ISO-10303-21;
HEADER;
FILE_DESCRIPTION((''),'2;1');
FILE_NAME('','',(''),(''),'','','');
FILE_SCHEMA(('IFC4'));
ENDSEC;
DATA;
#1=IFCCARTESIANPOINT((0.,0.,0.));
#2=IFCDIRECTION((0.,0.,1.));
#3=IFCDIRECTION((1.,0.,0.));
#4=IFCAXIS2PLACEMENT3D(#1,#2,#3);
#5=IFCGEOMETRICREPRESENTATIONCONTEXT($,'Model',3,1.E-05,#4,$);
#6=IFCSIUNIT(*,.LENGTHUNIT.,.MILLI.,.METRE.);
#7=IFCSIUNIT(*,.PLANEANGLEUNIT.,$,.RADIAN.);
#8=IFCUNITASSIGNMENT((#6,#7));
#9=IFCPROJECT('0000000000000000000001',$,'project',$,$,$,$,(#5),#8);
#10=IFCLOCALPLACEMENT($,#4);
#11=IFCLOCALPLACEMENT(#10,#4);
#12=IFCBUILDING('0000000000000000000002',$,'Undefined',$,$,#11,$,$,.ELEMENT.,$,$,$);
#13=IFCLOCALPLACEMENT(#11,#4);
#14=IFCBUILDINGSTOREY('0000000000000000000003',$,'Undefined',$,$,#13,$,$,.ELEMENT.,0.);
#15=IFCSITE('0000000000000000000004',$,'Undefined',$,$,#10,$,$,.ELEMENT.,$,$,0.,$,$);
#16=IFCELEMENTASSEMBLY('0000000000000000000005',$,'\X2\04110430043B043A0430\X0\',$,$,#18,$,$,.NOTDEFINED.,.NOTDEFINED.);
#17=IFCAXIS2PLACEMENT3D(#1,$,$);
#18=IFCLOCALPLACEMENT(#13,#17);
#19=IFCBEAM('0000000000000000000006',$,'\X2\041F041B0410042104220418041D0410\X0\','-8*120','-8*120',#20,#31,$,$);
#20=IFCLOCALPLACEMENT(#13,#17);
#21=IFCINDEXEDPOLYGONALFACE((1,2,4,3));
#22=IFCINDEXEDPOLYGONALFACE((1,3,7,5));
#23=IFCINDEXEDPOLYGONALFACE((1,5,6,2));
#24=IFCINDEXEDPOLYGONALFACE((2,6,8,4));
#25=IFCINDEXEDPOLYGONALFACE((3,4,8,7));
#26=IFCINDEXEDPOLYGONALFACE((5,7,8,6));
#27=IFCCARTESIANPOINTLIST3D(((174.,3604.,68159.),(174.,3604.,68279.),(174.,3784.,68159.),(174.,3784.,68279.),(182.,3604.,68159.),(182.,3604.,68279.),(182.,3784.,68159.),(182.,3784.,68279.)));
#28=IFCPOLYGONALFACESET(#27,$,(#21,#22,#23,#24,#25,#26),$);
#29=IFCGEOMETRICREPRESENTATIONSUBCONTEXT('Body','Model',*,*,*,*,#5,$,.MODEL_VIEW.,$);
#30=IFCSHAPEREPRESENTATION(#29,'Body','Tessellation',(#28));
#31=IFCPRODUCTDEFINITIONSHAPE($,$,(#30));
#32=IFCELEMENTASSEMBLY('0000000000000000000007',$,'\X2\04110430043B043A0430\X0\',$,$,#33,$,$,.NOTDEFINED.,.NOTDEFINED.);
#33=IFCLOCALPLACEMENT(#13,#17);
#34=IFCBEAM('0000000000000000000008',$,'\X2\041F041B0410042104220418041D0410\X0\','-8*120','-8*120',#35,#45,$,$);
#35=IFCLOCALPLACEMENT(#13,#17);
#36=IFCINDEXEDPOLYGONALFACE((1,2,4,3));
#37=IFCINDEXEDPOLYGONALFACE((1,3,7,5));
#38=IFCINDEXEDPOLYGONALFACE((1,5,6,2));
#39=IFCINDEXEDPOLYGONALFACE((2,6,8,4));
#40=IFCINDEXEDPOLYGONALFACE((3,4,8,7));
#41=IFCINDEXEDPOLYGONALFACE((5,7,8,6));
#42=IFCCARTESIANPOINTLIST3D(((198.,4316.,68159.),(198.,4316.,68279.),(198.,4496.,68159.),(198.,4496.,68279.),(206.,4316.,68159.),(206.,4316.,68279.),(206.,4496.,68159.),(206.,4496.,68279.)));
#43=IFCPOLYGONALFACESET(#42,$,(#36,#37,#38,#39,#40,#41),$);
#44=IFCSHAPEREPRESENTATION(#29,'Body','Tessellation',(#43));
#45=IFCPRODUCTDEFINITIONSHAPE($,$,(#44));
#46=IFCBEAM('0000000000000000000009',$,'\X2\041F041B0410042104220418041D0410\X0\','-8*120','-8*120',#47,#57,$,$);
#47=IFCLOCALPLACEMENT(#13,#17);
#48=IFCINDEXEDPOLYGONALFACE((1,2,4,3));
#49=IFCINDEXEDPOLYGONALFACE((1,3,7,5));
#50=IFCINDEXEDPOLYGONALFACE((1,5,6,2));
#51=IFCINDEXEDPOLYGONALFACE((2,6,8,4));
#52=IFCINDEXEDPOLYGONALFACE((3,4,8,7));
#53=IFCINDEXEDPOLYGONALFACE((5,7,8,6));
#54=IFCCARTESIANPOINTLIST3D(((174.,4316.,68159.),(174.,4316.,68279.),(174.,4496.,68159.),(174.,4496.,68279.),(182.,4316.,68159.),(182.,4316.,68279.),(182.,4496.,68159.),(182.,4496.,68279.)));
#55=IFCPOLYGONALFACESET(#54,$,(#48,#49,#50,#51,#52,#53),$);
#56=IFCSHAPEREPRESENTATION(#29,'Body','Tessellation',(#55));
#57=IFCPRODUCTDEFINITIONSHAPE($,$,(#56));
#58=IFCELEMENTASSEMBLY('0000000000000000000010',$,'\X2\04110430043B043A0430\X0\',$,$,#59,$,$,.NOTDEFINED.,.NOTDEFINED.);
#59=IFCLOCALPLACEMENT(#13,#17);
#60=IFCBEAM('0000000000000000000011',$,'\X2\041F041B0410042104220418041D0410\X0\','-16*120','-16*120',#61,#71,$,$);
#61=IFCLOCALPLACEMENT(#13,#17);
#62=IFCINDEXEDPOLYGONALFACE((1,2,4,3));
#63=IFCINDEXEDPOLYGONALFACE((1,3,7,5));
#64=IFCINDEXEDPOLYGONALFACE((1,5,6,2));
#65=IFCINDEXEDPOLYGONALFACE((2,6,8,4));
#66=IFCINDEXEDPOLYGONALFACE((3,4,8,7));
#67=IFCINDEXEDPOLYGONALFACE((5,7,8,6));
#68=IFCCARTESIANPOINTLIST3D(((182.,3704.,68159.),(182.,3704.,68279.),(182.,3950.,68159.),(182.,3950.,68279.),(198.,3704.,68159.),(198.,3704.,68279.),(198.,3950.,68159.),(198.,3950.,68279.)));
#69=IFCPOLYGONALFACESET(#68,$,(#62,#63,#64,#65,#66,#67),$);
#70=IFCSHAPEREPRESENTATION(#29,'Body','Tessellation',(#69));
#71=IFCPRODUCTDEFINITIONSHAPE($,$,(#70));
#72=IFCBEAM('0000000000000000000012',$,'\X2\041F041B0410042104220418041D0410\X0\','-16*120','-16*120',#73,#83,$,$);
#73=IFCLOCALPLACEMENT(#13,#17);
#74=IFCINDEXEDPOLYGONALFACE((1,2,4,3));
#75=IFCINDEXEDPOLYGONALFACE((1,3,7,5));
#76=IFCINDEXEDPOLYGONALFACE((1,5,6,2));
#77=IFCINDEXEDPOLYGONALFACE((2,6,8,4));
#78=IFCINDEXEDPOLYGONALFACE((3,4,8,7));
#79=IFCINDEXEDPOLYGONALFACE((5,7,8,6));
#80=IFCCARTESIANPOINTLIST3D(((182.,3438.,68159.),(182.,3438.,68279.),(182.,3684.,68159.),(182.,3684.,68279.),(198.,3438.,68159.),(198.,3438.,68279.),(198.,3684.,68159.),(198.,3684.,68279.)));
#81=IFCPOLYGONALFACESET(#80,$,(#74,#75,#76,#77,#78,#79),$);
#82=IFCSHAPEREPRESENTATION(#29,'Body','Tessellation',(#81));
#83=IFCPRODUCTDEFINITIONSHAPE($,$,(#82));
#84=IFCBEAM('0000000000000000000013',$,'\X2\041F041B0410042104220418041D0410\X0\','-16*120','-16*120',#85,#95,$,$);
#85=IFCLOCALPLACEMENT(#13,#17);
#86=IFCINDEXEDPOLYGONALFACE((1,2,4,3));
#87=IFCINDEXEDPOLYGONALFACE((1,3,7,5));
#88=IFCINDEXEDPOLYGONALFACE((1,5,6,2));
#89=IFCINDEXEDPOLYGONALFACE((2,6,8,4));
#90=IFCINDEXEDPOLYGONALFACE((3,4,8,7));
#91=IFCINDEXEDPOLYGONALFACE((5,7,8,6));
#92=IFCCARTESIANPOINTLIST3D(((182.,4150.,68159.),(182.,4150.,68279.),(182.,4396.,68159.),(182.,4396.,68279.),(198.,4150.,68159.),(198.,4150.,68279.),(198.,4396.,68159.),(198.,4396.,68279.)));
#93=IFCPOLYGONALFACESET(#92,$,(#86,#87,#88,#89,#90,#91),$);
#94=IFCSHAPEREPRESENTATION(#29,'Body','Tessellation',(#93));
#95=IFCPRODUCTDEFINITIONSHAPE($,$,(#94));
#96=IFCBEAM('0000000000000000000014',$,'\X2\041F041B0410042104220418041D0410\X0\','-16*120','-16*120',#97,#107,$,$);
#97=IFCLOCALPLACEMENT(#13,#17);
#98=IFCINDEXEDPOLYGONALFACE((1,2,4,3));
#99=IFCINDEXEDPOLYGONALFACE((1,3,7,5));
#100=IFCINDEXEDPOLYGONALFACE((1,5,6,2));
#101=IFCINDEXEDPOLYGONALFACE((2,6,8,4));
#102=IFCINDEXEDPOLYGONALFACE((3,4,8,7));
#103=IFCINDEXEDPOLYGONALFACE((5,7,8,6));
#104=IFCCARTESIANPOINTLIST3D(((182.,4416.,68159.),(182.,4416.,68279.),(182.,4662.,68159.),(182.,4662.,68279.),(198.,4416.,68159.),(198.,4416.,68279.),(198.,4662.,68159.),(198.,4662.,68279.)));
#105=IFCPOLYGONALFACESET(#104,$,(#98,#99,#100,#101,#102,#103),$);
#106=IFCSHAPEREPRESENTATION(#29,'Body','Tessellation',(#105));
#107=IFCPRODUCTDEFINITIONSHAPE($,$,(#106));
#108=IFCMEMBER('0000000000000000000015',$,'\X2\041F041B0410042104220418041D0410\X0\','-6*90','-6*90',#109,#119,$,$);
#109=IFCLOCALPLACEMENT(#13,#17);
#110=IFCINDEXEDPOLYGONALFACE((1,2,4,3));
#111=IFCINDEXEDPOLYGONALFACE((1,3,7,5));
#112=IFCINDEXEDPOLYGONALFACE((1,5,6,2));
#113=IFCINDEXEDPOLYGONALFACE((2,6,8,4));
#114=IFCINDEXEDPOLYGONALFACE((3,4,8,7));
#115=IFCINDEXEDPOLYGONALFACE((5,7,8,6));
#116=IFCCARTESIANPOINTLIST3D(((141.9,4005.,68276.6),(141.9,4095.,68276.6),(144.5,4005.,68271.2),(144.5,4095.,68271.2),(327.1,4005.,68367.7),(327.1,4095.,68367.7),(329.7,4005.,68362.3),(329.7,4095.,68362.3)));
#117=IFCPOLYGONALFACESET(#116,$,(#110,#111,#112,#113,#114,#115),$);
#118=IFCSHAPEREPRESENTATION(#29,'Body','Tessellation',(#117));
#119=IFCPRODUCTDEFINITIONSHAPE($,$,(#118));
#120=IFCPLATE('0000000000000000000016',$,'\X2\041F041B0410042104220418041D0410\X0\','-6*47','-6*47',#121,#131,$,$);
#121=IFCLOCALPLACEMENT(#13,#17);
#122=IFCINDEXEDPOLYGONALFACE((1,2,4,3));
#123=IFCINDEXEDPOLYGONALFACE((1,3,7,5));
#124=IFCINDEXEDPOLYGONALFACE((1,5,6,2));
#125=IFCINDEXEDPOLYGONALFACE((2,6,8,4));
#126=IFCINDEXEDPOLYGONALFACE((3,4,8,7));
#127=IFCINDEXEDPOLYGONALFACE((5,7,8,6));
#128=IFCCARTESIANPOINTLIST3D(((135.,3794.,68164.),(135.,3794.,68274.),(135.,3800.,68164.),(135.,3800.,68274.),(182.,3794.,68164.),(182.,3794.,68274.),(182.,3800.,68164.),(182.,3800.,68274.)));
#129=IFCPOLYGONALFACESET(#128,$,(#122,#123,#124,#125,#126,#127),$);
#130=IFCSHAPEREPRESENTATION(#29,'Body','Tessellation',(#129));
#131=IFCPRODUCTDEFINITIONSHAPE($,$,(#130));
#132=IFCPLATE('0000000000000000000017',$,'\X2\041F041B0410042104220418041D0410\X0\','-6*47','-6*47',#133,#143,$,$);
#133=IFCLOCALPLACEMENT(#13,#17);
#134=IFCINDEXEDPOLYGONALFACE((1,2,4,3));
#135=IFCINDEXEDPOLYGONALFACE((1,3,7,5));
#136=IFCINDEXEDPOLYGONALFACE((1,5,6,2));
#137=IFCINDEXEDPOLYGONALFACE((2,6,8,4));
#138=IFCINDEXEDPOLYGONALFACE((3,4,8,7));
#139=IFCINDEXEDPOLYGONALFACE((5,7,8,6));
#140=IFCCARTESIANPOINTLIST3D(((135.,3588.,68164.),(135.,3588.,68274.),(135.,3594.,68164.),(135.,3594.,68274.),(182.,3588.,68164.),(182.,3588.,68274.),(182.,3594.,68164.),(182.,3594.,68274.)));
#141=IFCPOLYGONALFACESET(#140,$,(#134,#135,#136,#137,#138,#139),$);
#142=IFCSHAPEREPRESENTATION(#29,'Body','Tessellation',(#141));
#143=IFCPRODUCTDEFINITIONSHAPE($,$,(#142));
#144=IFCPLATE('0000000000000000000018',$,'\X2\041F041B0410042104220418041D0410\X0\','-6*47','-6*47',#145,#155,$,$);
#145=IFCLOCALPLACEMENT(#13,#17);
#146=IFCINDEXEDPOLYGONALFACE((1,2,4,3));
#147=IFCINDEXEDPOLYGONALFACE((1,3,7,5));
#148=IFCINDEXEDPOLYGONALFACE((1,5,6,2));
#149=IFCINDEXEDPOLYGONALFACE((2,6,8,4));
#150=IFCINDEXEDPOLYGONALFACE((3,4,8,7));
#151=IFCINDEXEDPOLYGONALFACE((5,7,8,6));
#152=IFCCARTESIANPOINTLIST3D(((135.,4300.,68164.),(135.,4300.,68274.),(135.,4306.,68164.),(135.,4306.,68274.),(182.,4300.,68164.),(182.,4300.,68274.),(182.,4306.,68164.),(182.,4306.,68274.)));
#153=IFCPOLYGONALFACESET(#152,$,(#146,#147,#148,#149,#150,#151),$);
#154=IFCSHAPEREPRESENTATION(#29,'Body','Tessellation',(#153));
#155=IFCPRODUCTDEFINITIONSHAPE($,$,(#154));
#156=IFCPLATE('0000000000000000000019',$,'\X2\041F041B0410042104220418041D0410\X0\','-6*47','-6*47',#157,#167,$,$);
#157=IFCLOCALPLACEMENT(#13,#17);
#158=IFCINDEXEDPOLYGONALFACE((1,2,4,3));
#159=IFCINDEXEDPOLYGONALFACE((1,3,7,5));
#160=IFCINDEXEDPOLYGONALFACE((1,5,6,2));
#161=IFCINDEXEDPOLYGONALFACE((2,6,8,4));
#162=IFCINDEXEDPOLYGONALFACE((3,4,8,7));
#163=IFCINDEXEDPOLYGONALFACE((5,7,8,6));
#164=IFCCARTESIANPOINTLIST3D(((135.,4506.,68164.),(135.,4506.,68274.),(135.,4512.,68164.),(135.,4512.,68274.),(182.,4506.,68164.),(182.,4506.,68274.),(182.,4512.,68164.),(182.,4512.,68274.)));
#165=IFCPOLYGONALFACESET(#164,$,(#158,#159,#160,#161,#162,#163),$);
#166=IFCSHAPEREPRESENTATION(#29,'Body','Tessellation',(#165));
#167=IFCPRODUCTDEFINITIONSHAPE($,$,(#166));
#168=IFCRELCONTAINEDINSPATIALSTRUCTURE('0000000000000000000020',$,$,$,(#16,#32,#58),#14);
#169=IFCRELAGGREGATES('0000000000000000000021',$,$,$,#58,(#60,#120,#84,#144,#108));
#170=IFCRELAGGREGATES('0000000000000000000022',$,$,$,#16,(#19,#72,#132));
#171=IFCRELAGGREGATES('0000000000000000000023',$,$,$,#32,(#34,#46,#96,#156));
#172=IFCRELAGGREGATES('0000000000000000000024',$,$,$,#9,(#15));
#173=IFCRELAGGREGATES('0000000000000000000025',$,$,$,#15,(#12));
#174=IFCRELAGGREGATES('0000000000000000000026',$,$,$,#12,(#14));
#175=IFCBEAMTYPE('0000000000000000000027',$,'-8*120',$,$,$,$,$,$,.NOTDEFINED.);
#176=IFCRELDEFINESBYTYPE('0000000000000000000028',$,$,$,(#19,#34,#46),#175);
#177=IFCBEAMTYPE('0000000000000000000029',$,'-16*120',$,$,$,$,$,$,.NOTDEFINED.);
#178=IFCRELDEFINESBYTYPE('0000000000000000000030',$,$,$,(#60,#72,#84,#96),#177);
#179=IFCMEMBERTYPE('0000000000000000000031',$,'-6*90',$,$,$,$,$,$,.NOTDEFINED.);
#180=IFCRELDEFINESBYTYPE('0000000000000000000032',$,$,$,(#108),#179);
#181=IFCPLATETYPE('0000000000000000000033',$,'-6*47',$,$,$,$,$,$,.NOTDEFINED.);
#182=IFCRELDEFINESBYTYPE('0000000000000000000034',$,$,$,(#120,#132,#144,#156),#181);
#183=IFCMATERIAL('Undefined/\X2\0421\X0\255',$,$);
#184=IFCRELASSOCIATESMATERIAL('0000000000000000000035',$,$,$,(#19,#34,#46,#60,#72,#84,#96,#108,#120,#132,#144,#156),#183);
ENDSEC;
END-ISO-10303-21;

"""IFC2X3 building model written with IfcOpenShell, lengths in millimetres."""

from ifc_helpers import new_model, si_unit, frame, origin_with_axes, origin_2d_with_axis, place, context, subcontext, project, spatial, polyline, rectangle, outline, extrude, boolean, material, type_object, element, aggregate, save


model = new_model("IFC2X3")

# Units and contexts
model_context = context("Model", 3, precision=1e-05, world=origin_with_axes())
body_context = subcontext(model_context, "Body", "Model", "MODEL_VIEW")
ifc_project = project(units=[si_unit("LENGTHUNIT", "METRE", prefix="MILLI"), si_unit("PLANEANGLEUNIT", "RADIAN")], contexts=[model_context])

# Site, building, storey
site_placement = place(None, origin_with_axes())
site = spatial("IfcSite", under=ifc_project, at=site_placement, Name="Undefined", CompositionType="ELEMENT", RefElevation=0.0)
building_placement = place(site_placement, origin_with_axes())
building = spatial("IfcBuilding", under=site, at=building_placement, Name="Undefined", CompositionType="ELEMENT")
storey_placement = place(building_placement, origin_with_axes())
storey = spatial("IfcBuildingStorey", under=building, at=storey_placement, Name="Undefined", CompositionType="ELEMENT", Elevation=0.0)

# Element assembly, beam
assembly_1_placement = place(storey_placement, origin_with_axes())
assembly_1 = element("IfcElementAssembly", 1, at=assembly_1_placement, inside=storey, Name="Балка", AssemblyPlace="NOTDEFINED", PredefinedType="NOTDEFINED")
ifc_material_1 = material(Name="Undefined/С255")
beam_type_1 = type_object("IfcBeamType", Name="-8*120", PredefinedType="NOTDEFINED")
beam_1_placement = place(assembly_1_placement, frame((178.0, 3604.0, 68219.0), z_axis=(0.0, 0.0, 1.0), x_axis=(0.0, 1.0, 0.0)))
beam_1 = element("IfcBeam", 2, at=beam_1_placement, type_object=beam_type_1, material=ifc_material_1, Name="ПЛАСТИНА", Description="-8*120", ObjectType="-8*120", context=body_context, shape_type="SweptSolid", body=[
    extrude(rectangle(XDim=8.0, YDim=120.0, at=origin_2d_with_axis()), frame((180.0, 0.0, 0.0), z_axis=(-1.0, 0.0, 0.0), x_axis=(0.0, -1.0, 0.0)), (0.0, 0.0, 1.0), 180.0),
])

# Element assembly, beams
assembly_2_placement = place(storey_placement, origin_with_axes())
assembly_2 = element("IfcElementAssembly", 3, at=assembly_2_placement, inside=storey, Name="Балка", AssemblyPlace="NOTDEFINED", PredefinedType="NOTDEFINED")
beam_2_placement = place(assembly_2_placement, frame((202.0, 4496.0, 68219.0), z_axis=(0.0, 0.0, -1.0), x_axis=(0.0, -1.0, 0.0)))
beam_2 = element("IfcBeam", 4, at=beam_2_placement, type_object=beam_type_1, material=ifc_material_1, Name="ПЛАСТИНА", Description="-8*120", ObjectType="-8*120", context=body_context, shape_type="SweptSolid", body=[
    extrude(rectangle(XDim=8.0, YDim=120.0, at=origin_2d_with_axis()), frame((180.0, 0.0, 0.0), z_axis=(-1.0, 0.0, 0.0), x_axis=(0.0, -1.0, 0.0)), (0.0, 0.0, 1.0), 180.0),
])
beam_3_placement = place(assembly_2_placement, frame((178.0, 4496.0, 68219.0), z_axis=(0.0, 0.0, -1.0), x_axis=(0.0, -1.0, 0.0)))
beam_3 = element("IfcBeam", 5, at=beam_3_placement, type_object=beam_type_1, material=ifc_material_1, Name="ПЛАСТИНА", Description="-8*120", ObjectType="-8*120", context=body_context, shape_type="SweptSolid", body=[
    extrude(rectangle(XDim=8.0, YDim=120.0, at=origin_2d_with_axis()), frame((180.0, 0.0, 0.0), z_axis=(-1.0, 0.0, 0.0), x_axis=(0.0, -1.0, 0.0)), (0.0, 0.0, 1.0), 180.0),
])

# Element assembly, beam
assembly_3_placement = place(storey_placement, origin_with_axes())
assembly_3 = element("IfcElementAssembly", 6, at=assembly_3_placement, inside=storey, Name="Балка", AssemblyPlace="NOTDEFINED", PredefinedType="NOTDEFINED")
beam_type_2 = type_object("IfcBeamType", Name="-16*120", PredefinedType="NOTDEFINED")
beam_4_placement = place(assembly_3_placement, frame((190.0, 3704.0, 68219.0), z_axis=(0.0, 0.0, 1.0), x_axis=(0.0, 1.0, 0.0)))
beam_4 = element("IfcBeam", 7, at=beam_4_placement, type_object=beam_type_2, material=ifc_material_1, Name="ПЛАСТИНА", Description="-16*120", ObjectType="-16*120", context=body_context, shape_type="SweptSolid", body=[
    extrude(rectangle(XDim=16.0, YDim=120.0, at=origin_2d_with_axis()), frame((246.0, 0.0, 0.0), z_axis=(-1.0, 0.0, 0.0), x_axis=(0.0, -1.0, 0.0)), (0.0, 0.0, 1.0), 246.0),
])

# Beams
beam_5_placement = place(assembly_1_placement, frame((190.0, 3438.0, 68219.0), z_axis=(0.0, 0.0, 1.0), x_axis=(0.0, 1.0, 0.0)))
beam_5 = element("IfcBeam", 8, at=beam_5_placement, type_object=beam_type_2, material=ifc_material_1, Name="ПЛАСТИНА", Description="-16*120", ObjectType="-16*120", context=body_context, shape_type="SweptSolid", body=[
    extrude(rectangle(XDim=16.0, YDim=120.0, at=origin_2d_with_axis()), frame((246.0, 0.0, 0.0), z_axis=(-1.0, 0.0, 0.0), x_axis=(0.0, -1.0, 0.0)), (0.0, 0.0, 1.0), 246.0),
])
beam_6_placement = place(assembly_3_placement, frame((190.0, 4396.0, 68219.0), z_axis=(0.0, 0.0, -1.0), x_axis=(0.0, -1.0, 0.0)))
beam_6 = element("IfcBeam", 9, at=beam_6_placement, type_object=beam_type_2, material=ifc_material_1, Name="ПЛАСТИНА", Description="-16*120", ObjectType="-16*120", context=body_context, shape_type="SweptSolid", body=[
    extrude(rectangle(XDim=16.0, YDim=120.0, at=origin_2d_with_axis()), frame((246.0, 0.0, 0.0), z_axis=(-1.0, 0.0, 0.0), x_axis=(0.0, -1.0, 0.0)), (0.0, 0.0, 1.0), 246.0),
])
beam_7_placement = place(assembly_2_placement, frame((190.0, 4662.0, 68219.0), z_axis=(0.0, 0.0, -1.0), x_axis=(0.0, -1.0, 0.0)))
beam_7 = element("IfcBeam", 10, at=beam_7_placement, type_object=beam_type_2, material=ifc_material_1, Name="ПЛАСТИНА", Description="-16*120", ObjectType="-16*120", context=body_context, shape_type="SweptSolid", body=[
    extrude(rectangle(XDim=16.0, YDim=120.0, at=origin_2d_with_axis()), frame((246.0, 0.0, 0.0), z_axis=(-1.0, 0.0, 0.0), x_axis=(0.0, -1.0, 0.0)), (0.0, 0.0, 1.0), 246.0),
])

# Member
member_type = type_object("IfcMemberType", Name="-6*90", PredefinedType="NOTDEFINED")
member_placement = place(assembly_3_placement, frame((143.2, 4050.0, 68273.9), z_axis=(0.0, -1.0, 0.0), x_axis=(0.897399, 0.0, 0.441221)))
member = element("IfcMember", 11, at=member_placement, type_object=member_type, material=ifc_material_1, Name="ПЛАСТИНА", Description="-6*90", ObjectType="-6*90", context=body_context, shape_type="SweptSolid", body=[
    extrude(rectangle(XDim=6.0, YDim=90.0, at=origin_2d_with_axis()), frame((206.4, 0.0, 0.0), z_axis=(-1.0, 0.0, 0.0), x_axis=(0.0, -1.0, 0.0)), (0.0, 0.0, 1.0), 206.4),
])

# Plates
plate_type = type_object("IfcPlateType", Name="-6*47", PredefinedType="NOTDEFINED")
plate_1_placement = place(assembly_3_placement, frame((135.0, 3797.0, 68274.0), z_axis=(0.0, -1.0, 0.0), x_axis=(0.0, 0.0, -1.0)))
plate_1 = element("IfcPlate", 12, at=plate_1_placement, type_object=plate_type, material=ifc_material_1, Name="ПЛАСТИНА", Description="-6*47", ObjectType="-6*47", context=body_context, shape_type="CSG", body=[
    boolean("DIFFERENCE", extrude(outline(polyline([(0.0, 0.0), (110.0, 0.0), (110.0, 110.0), (0.0, 110.0), (0.0, 0.0)])), frame((0.0, 0.0, -3.0), z_axis=(0.0, 0.0, 1.0), x_axis=(1.0, 0.0, 0.0)), (0.0, 0.0, 1.0), 6.0), extrude(rectangle(XDim=26.0, YDim=130.0, at=origin_2d_with_axis()), frame((55.0, 47.0, 0.0), z_axis=(0.0, 1.0, 0.0), x_axis=(0.0, 0.0, -1.0)), (0.0, 0.0, 1.0), 66.0)),
])
plate_2_placement = place(assembly_1_placement, frame((135.0, 3591.0, 68164.0), z_axis=(0.0, 1.0, 0.0), x_axis=(0.0, 0.0, 1.0)))
plate_2 = element("IfcPlate", 13, at=plate_2_placement, type_object=plate_type, material=ifc_material_1, Name="ПЛАСТИНА", Description="-6*47", ObjectType="-6*47", context=body_context, shape_type="CSG", body=[
    boolean("DIFFERENCE", extrude(outline(polyline([(0.0, 0.0), (110.0, 0.0), (110.0, 110.0), (0.0, 110.0), (0.0, 0.0)])), frame((0.0, 0.0, -3.0), z_axis=(0.0, 0.0, 1.0), x_axis=(1.0, 0.0, 0.0)), (0.0, 0.0, 1.0), 6.0), extrude(rectangle(XDim=26.0, YDim=130.0, at=origin_2d_with_axis()), frame((55.0, 47.0, 0.0), z_axis=(0.0, 1.0, 0.0), x_axis=(0.0, 0.0, -1.0)), (0.0, 0.0, 1.0), 66.0)),
])
plate_3_placement = place(assembly_3_placement, frame((135.0, 4303.0, 68164.0), z_axis=(0.0, 1.0, 0.0), x_axis=(0.0, 0.0, 1.0)))
plate_3 = element("IfcPlate", 14, at=plate_3_placement, type_object=plate_type, material=ifc_material_1, Name="ПЛАСТИНА", Description="-6*47", ObjectType="-6*47", context=body_context, shape_type="CSG", body=[
    boolean("DIFFERENCE", extrude(outline(polyline([(0.0, 0.0), (110.0, 0.0), (110.0, 110.0), (0.0, 110.0), (0.0, 0.0)])), frame((0.0, 0.0, -3.0), z_axis=(0.0, 0.0, 1.0), x_axis=(1.0, 0.0, 0.0)), (0.0, 0.0, 1.0), 6.0), extrude(rectangle(XDim=26.0, YDim=130.0, at=origin_2d_with_axis()), frame((55.0, 47.0, 0.0), z_axis=(0.0, 1.0, 0.0), x_axis=(0.0, 0.0, -1.0)), (0.0, 0.0, 1.0), 66.0)),
])
aggregate(assembly_3, [beam_4, plate_1, beam_6, plate_3, member])
plate_4_placement = place(assembly_2_placement, frame((135.0, 4509.0, 68274.0), z_axis=(0.0, -1.0, 0.0), x_axis=(0.0, 0.0, -1.0)))
plate_4 = element("IfcPlate", 15, at=plate_4_placement, type_object=plate_type, material=ifc_material_1, Name="ПЛАСТИНА", Description="-6*47", ObjectType="-6*47", context=body_context, shape_type="CSG", body=[
    boolean("DIFFERENCE", extrude(outline(polyline([(0.0, 0.0), (110.0, 0.0), (110.0, 110.0), (0.0, 110.0), (0.0, 0.0)])), frame((0.0, 0.0, -3.0), z_axis=(0.0, 0.0, 1.0), x_axis=(1.0, 0.0, 0.0)), (0.0, 0.0, 1.0), 6.0), extrude(rectangle(XDim=26.0, YDim=130.0, at=origin_2d_with_axis()), frame((55.0, 47.0, 0.0), z_axis=(0.0, 1.0, 0.0), x_axis=(0.0, 0.0, -1.0)), (0.0, 0.0, 1.0), 66.0)),
])

aggregate(assembly_1, [beam_1, beam_5, plate_2])
aggregate(assembly_2, [beam_2, beam_3, beam_7, plate_4])

save(model, "model.ifc")
